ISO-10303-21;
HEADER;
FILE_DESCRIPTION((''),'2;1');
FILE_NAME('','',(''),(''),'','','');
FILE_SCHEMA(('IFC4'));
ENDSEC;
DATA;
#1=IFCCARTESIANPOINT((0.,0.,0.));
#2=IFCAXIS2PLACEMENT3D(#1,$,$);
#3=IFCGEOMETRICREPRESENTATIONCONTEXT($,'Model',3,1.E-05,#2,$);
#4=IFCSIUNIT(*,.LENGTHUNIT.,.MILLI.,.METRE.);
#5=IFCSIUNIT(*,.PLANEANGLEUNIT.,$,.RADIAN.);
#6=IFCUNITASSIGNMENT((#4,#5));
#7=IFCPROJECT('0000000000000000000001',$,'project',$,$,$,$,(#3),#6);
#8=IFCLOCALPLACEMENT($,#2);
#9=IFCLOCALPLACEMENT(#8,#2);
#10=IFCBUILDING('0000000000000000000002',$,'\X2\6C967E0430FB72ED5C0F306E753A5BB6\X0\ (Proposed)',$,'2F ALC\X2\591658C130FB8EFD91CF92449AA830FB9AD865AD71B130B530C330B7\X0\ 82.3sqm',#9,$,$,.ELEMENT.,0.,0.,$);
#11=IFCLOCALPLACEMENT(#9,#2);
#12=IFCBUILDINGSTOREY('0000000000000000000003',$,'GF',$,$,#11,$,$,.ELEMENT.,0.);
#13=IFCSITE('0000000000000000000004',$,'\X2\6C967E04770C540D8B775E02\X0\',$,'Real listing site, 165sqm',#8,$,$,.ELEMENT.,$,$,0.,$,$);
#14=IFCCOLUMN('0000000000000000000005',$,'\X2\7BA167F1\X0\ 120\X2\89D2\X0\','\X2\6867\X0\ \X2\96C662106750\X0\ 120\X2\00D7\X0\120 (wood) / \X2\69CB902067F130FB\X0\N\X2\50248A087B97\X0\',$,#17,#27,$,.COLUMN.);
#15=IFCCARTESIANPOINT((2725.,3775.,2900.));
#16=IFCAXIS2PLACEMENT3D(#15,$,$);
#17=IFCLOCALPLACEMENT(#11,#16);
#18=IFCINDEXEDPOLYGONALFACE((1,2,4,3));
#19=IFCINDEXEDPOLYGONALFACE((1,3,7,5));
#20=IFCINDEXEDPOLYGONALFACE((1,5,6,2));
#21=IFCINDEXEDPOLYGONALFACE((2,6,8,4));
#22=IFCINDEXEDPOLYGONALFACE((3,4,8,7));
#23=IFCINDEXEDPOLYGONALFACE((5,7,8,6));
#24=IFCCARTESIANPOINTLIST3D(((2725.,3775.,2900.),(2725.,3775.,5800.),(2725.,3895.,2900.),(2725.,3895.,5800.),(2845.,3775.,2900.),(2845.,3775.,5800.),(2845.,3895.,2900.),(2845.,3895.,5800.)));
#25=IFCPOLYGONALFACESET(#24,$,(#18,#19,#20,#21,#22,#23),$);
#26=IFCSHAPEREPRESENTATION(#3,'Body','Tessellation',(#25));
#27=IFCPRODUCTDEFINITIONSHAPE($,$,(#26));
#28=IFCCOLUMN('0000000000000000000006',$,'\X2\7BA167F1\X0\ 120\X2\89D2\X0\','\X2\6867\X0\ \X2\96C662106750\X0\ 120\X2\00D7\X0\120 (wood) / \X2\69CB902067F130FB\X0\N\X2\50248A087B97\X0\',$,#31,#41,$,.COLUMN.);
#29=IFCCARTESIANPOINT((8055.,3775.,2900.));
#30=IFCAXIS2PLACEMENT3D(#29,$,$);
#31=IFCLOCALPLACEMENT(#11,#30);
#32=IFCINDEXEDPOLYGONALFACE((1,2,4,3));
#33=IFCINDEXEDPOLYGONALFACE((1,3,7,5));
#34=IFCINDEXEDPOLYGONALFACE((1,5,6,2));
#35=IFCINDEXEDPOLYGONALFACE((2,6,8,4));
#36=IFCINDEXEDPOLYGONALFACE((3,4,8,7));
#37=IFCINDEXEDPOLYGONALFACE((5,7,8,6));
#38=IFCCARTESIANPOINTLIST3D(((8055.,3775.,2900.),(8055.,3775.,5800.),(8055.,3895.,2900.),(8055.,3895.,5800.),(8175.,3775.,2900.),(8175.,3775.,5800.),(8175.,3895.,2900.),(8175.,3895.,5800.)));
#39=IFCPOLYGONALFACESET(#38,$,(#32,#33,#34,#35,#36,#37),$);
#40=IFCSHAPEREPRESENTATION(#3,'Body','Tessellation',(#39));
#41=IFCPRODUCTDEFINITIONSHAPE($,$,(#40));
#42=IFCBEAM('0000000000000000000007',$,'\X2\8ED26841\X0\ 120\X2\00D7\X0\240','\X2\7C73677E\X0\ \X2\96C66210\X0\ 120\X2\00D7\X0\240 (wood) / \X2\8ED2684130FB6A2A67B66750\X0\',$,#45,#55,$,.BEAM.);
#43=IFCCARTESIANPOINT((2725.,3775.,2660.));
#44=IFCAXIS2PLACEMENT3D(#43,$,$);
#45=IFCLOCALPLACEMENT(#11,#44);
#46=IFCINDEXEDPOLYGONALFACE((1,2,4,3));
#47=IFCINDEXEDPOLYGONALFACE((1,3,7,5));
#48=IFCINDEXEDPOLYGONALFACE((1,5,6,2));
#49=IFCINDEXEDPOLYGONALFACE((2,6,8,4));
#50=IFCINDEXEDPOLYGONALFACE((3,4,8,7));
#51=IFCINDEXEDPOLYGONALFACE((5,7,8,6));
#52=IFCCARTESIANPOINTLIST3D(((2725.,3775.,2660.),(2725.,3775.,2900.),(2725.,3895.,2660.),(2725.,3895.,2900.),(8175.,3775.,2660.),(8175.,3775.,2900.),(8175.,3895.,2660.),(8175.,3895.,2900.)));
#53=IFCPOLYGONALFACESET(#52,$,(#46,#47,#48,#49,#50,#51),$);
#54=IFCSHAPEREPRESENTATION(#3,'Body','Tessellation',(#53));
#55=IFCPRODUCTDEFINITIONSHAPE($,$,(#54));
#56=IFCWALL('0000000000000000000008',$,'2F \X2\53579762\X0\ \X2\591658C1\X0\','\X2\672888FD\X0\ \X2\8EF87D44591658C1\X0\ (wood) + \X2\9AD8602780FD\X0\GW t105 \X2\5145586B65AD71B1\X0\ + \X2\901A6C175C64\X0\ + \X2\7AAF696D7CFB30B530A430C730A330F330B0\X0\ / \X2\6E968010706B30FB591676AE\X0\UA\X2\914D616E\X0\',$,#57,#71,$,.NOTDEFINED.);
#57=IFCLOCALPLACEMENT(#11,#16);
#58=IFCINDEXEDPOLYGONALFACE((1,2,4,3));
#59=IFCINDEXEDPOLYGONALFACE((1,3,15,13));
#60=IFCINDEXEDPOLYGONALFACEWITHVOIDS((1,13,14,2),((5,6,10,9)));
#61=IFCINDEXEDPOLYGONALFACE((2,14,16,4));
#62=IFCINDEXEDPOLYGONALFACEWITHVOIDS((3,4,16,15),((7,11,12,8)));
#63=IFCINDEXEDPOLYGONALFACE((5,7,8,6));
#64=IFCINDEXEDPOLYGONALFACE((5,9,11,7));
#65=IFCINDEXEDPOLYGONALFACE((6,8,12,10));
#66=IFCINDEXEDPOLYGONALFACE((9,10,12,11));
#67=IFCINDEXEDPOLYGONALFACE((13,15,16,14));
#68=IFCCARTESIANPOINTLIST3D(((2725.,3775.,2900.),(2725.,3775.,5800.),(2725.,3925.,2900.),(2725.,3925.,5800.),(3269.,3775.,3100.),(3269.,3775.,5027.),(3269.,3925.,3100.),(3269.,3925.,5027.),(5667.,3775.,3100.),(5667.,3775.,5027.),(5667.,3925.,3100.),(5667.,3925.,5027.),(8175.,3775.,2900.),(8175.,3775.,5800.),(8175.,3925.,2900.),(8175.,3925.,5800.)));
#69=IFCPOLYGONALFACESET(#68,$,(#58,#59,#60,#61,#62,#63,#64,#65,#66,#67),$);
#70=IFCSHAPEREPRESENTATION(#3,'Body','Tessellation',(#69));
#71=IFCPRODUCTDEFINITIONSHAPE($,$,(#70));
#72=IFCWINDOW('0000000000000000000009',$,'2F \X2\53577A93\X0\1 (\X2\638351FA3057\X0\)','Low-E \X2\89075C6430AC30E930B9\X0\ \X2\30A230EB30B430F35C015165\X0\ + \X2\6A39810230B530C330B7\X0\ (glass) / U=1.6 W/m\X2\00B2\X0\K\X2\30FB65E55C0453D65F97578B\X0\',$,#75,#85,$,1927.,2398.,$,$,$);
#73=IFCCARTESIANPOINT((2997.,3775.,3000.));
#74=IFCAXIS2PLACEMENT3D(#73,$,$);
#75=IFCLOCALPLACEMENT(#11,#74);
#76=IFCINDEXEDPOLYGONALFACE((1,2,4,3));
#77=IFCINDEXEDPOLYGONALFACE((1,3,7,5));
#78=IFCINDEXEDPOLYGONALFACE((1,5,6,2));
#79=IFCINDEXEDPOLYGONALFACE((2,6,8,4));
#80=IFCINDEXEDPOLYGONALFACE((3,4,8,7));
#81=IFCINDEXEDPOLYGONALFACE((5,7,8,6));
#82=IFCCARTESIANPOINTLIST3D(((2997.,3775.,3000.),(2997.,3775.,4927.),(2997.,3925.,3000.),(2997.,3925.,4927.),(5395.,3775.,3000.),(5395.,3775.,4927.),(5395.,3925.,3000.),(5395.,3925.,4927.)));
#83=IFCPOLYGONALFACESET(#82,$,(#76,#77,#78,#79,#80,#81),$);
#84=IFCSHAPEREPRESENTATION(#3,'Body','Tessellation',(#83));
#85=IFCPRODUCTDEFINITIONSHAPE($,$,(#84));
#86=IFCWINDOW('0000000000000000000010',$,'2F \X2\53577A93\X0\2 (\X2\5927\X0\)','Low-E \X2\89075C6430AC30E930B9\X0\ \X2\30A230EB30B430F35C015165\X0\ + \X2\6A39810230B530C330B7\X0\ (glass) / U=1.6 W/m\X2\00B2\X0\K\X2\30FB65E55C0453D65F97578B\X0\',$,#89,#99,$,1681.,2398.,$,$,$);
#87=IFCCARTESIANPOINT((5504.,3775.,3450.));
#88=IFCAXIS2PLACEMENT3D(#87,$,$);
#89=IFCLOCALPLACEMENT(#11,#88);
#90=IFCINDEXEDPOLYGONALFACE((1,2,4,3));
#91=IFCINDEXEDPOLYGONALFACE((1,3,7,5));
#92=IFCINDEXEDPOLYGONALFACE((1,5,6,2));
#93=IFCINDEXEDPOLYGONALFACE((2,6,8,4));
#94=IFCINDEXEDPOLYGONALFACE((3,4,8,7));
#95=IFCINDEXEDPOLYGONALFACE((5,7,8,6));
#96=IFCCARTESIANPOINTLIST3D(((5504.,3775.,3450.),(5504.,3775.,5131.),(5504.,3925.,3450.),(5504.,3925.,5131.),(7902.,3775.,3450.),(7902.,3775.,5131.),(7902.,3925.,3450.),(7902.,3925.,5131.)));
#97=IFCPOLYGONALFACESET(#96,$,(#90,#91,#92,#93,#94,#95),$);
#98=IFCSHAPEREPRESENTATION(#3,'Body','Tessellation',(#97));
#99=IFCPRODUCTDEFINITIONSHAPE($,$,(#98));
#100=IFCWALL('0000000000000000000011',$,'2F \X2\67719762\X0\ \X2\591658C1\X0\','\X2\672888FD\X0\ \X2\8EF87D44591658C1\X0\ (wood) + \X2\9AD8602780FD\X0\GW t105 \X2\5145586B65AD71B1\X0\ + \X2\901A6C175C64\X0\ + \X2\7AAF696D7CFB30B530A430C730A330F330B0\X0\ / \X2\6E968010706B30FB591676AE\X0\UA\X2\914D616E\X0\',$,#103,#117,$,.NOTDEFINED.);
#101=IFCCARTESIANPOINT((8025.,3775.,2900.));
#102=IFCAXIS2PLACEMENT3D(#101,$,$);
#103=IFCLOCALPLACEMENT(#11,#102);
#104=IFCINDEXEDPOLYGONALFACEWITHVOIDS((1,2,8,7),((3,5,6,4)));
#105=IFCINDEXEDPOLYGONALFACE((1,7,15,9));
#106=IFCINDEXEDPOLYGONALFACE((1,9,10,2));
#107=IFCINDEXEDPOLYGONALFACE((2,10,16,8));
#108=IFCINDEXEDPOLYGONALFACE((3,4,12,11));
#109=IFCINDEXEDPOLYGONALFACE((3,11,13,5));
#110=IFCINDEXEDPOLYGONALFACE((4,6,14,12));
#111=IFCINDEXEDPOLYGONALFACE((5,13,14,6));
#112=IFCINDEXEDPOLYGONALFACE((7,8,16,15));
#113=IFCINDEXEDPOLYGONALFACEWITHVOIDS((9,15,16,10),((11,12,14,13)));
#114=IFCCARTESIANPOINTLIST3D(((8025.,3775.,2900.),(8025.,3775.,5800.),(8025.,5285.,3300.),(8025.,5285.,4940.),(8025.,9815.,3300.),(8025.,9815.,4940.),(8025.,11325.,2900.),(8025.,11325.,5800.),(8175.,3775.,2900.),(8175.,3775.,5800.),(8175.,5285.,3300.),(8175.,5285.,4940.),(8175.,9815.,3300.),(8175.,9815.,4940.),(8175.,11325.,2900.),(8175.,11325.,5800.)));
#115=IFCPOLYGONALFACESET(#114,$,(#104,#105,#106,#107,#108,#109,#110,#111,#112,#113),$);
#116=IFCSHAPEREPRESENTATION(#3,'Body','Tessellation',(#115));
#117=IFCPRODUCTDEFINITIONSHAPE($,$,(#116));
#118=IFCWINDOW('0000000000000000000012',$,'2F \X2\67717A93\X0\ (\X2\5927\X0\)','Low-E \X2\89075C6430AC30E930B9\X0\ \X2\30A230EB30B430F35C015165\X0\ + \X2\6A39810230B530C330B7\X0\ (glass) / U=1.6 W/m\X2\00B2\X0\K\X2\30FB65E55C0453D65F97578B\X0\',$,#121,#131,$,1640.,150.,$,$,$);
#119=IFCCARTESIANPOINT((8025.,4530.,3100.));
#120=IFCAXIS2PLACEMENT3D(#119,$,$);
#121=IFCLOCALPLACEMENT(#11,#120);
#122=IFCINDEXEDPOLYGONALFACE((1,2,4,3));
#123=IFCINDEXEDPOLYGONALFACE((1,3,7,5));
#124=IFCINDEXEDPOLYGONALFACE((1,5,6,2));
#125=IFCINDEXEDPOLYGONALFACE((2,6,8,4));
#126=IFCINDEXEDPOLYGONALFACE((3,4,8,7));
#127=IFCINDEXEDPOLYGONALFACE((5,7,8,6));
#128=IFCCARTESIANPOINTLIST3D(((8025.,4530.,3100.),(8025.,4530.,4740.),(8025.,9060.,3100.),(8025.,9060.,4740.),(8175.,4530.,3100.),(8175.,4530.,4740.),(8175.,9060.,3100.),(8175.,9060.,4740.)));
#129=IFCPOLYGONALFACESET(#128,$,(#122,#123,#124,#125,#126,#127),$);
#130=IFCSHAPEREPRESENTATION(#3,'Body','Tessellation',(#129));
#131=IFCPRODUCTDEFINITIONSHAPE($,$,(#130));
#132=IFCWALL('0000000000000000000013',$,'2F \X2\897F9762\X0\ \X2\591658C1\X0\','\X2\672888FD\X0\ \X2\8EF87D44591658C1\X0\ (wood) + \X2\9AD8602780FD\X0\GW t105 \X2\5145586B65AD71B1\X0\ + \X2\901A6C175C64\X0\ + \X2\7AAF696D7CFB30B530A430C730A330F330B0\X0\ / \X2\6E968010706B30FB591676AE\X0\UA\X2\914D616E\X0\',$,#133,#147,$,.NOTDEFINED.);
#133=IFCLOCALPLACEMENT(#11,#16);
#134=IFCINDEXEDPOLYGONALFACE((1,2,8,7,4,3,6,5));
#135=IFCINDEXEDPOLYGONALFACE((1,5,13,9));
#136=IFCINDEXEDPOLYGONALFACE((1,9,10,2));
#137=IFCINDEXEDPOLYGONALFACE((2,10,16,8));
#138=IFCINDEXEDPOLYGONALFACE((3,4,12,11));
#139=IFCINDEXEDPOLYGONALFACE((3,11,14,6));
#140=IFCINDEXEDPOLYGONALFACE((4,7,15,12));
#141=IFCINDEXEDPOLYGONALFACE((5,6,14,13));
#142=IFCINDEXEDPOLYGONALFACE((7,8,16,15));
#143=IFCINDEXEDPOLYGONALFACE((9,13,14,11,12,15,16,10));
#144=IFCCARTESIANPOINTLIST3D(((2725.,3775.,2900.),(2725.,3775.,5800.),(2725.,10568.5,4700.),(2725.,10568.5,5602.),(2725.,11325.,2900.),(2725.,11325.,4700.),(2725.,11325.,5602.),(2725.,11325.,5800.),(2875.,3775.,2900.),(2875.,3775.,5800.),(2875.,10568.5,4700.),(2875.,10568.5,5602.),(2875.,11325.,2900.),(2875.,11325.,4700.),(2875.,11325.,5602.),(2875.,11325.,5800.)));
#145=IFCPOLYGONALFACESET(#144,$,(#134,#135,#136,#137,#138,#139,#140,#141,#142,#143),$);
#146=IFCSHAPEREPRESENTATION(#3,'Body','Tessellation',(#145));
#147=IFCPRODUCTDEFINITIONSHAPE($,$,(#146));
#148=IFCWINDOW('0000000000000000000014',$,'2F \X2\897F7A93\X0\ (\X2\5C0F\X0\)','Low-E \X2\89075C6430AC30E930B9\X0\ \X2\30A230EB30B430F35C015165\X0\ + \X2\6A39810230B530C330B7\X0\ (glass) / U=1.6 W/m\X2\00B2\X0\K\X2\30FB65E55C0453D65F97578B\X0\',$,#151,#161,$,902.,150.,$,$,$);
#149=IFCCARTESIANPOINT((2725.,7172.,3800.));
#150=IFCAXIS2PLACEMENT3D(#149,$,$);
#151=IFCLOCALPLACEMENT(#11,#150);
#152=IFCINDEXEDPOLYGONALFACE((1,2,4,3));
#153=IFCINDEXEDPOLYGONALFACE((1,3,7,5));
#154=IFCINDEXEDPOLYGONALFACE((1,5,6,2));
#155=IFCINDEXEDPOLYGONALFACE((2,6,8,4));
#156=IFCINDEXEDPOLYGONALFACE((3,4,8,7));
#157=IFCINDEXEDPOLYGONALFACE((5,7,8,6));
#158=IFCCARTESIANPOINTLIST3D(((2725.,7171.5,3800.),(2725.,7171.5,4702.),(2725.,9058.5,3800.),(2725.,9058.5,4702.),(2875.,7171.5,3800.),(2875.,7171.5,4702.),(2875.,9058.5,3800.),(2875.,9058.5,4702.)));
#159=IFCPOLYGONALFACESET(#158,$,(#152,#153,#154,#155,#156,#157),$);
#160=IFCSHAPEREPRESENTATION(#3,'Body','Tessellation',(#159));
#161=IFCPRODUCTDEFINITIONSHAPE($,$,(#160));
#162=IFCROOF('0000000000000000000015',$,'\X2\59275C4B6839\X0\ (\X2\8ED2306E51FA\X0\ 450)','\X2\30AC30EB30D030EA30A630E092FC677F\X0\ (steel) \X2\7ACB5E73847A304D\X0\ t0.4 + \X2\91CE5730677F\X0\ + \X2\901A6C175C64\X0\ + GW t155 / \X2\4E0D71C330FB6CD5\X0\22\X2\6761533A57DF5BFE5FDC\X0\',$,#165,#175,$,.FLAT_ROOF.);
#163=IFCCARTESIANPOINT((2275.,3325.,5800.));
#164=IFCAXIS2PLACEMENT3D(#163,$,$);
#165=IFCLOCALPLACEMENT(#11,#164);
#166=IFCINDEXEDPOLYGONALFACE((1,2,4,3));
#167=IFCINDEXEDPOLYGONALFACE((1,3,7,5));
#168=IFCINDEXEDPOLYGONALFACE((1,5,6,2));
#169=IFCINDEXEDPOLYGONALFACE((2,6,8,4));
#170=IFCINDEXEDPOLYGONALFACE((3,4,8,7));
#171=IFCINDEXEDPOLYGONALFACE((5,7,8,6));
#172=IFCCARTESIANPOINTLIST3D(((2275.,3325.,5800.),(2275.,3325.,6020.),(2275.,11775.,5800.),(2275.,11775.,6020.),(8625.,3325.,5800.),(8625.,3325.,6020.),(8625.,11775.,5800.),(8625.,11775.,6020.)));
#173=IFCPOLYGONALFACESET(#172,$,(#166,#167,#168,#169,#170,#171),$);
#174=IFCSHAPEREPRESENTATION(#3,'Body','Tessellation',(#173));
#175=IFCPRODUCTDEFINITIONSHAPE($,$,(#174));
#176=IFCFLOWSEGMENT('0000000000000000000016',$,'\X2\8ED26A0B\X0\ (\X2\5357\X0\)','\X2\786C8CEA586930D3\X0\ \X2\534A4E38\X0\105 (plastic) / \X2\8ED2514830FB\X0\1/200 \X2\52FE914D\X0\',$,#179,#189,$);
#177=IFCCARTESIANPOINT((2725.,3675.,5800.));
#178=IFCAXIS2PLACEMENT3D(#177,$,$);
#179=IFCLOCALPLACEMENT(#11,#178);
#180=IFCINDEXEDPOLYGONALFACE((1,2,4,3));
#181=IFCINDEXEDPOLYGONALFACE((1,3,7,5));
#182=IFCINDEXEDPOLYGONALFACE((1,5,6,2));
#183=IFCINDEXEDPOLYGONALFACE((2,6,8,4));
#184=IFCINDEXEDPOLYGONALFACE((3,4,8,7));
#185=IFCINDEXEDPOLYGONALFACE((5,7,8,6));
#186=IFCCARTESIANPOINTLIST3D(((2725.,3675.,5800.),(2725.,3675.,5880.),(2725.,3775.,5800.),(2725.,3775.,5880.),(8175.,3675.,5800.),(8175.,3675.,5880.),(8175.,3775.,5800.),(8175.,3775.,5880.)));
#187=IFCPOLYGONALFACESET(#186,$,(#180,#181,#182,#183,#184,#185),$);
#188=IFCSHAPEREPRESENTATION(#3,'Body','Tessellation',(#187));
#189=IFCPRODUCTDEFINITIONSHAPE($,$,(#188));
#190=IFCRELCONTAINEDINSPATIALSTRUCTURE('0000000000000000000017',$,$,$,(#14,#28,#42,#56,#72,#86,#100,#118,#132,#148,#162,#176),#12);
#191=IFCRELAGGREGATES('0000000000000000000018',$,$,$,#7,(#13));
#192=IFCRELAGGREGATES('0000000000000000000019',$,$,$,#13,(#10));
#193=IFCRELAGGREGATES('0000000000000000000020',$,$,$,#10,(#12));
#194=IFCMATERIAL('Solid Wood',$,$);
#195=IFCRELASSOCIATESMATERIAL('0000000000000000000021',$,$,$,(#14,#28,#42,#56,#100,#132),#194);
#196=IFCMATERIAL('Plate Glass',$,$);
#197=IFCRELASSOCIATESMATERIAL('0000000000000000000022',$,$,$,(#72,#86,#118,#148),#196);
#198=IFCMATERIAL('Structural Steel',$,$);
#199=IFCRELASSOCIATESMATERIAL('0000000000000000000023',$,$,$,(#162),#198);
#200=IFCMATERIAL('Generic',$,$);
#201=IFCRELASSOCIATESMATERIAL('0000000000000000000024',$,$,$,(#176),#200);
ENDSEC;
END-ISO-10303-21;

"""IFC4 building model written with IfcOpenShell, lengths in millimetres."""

from ifc_helpers import new_model, si_unit, frame, frame_2d, origin, place, context, project, spatial, rectangle, extrude, material, element, fill, save


model = new_model("IFC4")

# Units and contexts
model_context = context("Model", 3, precision=1e-05, world=origin())
ifc_project = project(units=[si_unit("LENGTHUNIT", "METRE", prefix="MILLI"), si_unit("PLANEANGLEUNIT", "RADIAN")], contexts=[model_context])

# Site, building, storey
site_placement = place(None, origin())
site = spatial("IfcSite", under=ifc_project, at=site_placement, Name="沖縄県名護市", ObjectType="Real listing site, 165sqm", CompositionType="ELEMENT", RefElevation=0.0)
building_placement = place(site_placement, origin())
building = spatial("IfcBuilding", under=site, at=building_placement, Name="沖縄・狭小の町家 (Proposed)", ObjectType="2F ALC外壁・軽量鉄骨・高断熱サッシ 82.3sqm", CompositionType="ELEMENT", ElevationOfRefHeight=0.0, ElevationOfTerrain=0.0)
storey_placement = place(building_placement, origin())
storey = spatial("IfcBuildingStorey", under=building, at=storey_placement, Name="GF", CompositionType="ELEMENT", Elevation=0.0)

# Columns
ifc_material_1 = material(Name="Solid Wood")
column_1_placement = place(storey_placement, frame((2725.0, 3775.0, 2900.0)))
element("IfcColumn", 1, at=column_1_placement, inside=storey, material=ifc_material_1, Name="管柱 120角", Description="桧 集成材 120×120 (wood) / 構造柱・N値計算", PredefinedType="COLUMN", context=model_context, shape_type="SweptSolid", body=[
    extrude(rectangle(XDim=120.0, YDim=120.0, at=frame_2d((60.0, 60.0))), frame((2725.0, 3775.0, 2900.0)), (0.0, 0.0, 1.0), 2900.0),
])
column_2_placement = place(storey_placement, frame((8055.0, 3775.0, 2900.0)))
element("IfcColumn", 2, at=column_2_placement, inside=storey, material=ifc_material_1, Name="管柱 120角", Description="桧 集成材 120×120 (wood) / 構造柱・N値計算", PredefinedType="COLUMN", context=model_context, shape_type="SweptSolid", body=[
    extrude(rectangle(XDim=120.0, YDim=120.0, at=frame_2d((60.0, 60.0))), frame((8055.0, 3775.0, 2900.0)), (0.0, 0.0, 1.0), 2900.0),
])

# Beam
beam_1_placement = place(storey_placement, frame((2725.0, 3775.0, 2660.0)))
element("IfcBeam", 3, at=beam_1_placement, inside=storey, material=ifc_material_1, Name="軒桁 120×240", Description="米松 集成 120×240 (wood) / 軒桁・横架材", PredefinedType="BEAM", context=model_context, shape_type="SweptSolid", body=[
    extrude(rectangle(XDim=5450.0, YDim=120.0, at=frame_2d((2725.0, 60.0))), frame((2725.0, 3775.0, 2660.0)), (0.0, 0.0, 1.0), 240.0),
])

# Wall, openings, windows
wall_1_placement = place(storey_placement, frame((2725.0, 3775.0, 2900.0)))
wall_1 = element("IfcWall", 4, at=wall_1_placement, inside=storey, material=ifc_material_1, Name="2F 南面 外壁", Description="木製 軸組外壁 (wood) + 高性能GW t105 充填断熱 + 通気層 + 窯業系サイディング / 準耐火・外皮UA配慮", PredefinedType="NOTDEFINED", context=model_context, shape_type="SweptSolid", body=[
    extrude(rectangle(XDim=5450.0, YDim=150.0, at=frame_2d((2725.0, 75.0))), frame((2725.0, 3775.0, 2900.0)), (0.0, 0.0, 1.0), 2900.0),
])
opening_1_placement = place(storey_placement, frame((2997.0, 3775.0, 3000.0)))
opening_1 = element("IfcOpeningElement", 5, at=opening_1_placement, cuts=wall_1, PredefinedType="NOTDEFINED", context=model_context, shape_type="SweptSolid", body=[
    extrude(rectangle(XDim=2398.0, YDim=150.0, at=frame_2d((1199.0, 75.0))), frame((2997.0, 3775.0, 3000.0)), (0.0, 0.0, 1.0), 1927.0),
])
opening_2_placement = place(storey_placement, frame((5504.0, 3775.0, 3450.0)))
opening_2 = element("IfcOpeningElement", 6, at=opening_2_placement, cuts=wall_1, PredefinedType="NOTDEFINED", context=model_context, shape_type="SweptSolid", body=[
    extrude(rectangle(XDim=2398.0, YDim=150.0, at=frame_2d((1199.0, 75.0))), frame((5504.0, 3775.0, 3450.0)), (0.0, 0.0, 1.0), 1681.0),
])
ifc_material_2 = material(Name="Plate Glass")
window_1_placement = place(storey_placement, frame((2997.0, 3775.0, 3000.0)))
window_1 = element("IfcWindow", 7, at=window_1_placement, inside=storey, material=ifc_material_2, Name="2F 南窓1 (掃出し)", Description="Low-E 複層ガラス アルゴン封入 + 樹脂サッシ (glass) / U=1.6 W/m²K・日射取得型", OverallHeight=1927.0, OverallWidth=2398.0, context=model_context, shape_type="SweptSolid", body=[
    extrude(rectangle(XDim=2398.0, YDim=150.0, at=frame_2d((1199.0, 75.0))), frame((2997.0, 3775.0, 3000.0)), (0.0, 0.0, 1.0), 1927.0),
])
fill(opening_1, window_1)
window_2_placement = place(storey_placement, frame((5504.0, 3775.0, 3450.0)))
window_2 = element("IfcWindow", 8, at=window_2_placement, inside=storey, material=ifc_material_2, Name="2F 南窓2 (大)", Description="Low-E 複層ガラス アルゴン封入 + 樹脂サッシ (glass) / U=1.6 W/m²K・日射取得型", OverallHeight=1681.0, OverallWidth=2398.0, context=model_context, shape_type="SweptSolid", body=[
    extrude(rectangle(XDim=2398.0, YDim=150.0, at=frame_2d((1199.0, 75.0))), frame((5504.0, 3775.0, 3450.0)), (0.0, 0.0, 1.0), 1681.0),
])
fill(opening_2, window_2)

# Walls, openings, windows
wall_2_placement = place(storey_placement, frame((8025.0, 3775.0, 2900.0)))
wall_2 = element("IfcWall", 9, at=wall_2_placement, inside=storey, material=ifc_material_1, Name="2F 東面 外壁", Description="木製 軸組外壁 (wood) + 高性能GW t105 充填断熱 + 通気層 + 窯業系サイディング / 準耐火・外皮UA配慮", PredefinedType="NOTDEFINED", context=model_context, shape_type="SweptSolid", body=[
    extrude(rectangle(XDim=150.0, YDim=7550.0, at=frame_2d((75.0, 3775.0))), frame((8025.0, 3775.0, 2900.0)), (0.0, 0.0, 1.0), 2900.0),
])
opening_3_placement = place(storey_placement, frame((8025.0, 4530.0, 3100.0)))
opening_3 = element("IfcOpeningElement", 10, at=opening_3_placement, cuts=wall_2, PredefinedType="NOTDEFINED", context=model_context, shape_type="SweptSolid", body=[
    extrude(rectangle(XDim=150.0, YDim=4530.0, at=frame_2d((75.0, 2265.0))), frame((8025.0, 4530.0, 3100.0)), (0.0, 0.0, 1.0), 1640.0),
])
window_3_placement = place(storey_placement, frame((8025.0, 4530.0, 3100.0)))
window_3 = element("IfcWindow", 11, at=window_3_placement, inside=storey, material=ifc_material_2, Name="2F 東窓 (大)", Description="Low-E 複層ガラス アルゴン封入 + 樹脂サッシ (glass) / U=1.6 W/m²K・日射取得型", OverallHeight=1640.0, OverallWidth=150.0, context=model_context, shape_type="SweptSolid", body=[
    extrude(rectangle(XDim=150.0, YDim=4530.0, at=frame_2d((75.0, 2265.0))), frame((8025.0, 4530.0, 3100.0)), (0.0, 0.0, 1.0), 1640.0),
])
fill(opening_3, window_3)
wall_3_placement = place(storey_placement, frame((2725.0, 3775.0, 2900.0)))
wall_3 = element("IfcWall", 12, at=wall_3_placement, inside=storey, material=ifc_material_1, Name="2F 西面 外壁", Description="木製 軸組外壁 (wood) + 高性能GW t105 充填断熱 + 通気層 + 窯業系サイディング / 準耐火・外皮UA配慮", PredefinedType="NOTDEFINED", context=model_context, shape_type="SweptSolid", body=[
    extrude(rectangle(XDim=150.0, YDim=7550.0, at=frame_2d((75.0, 3775.0))), frame((2725.0, 3775.0, 2900.0)), (0.0, 0.0, 1.0), 2900.0),
])
opening_4_placement = place(storey_placement, frame((2725.0, 7172.0, 3800.0)))
opening_4 = element("IfcOpeningElement", 13, at=opening_4_placement, cuts=wall_3, PredefinedType="NOTDEFINED", context=model_context, shape_type="SweptSolid", body=[
    extrude(rectangle(XDim=150.0, YDim=1887.0, at=frame_2d((75.0, 943.0))), frame((2725.0, 7172.0, 3800.0)), (0.0, 0.0, 1.0), 902.0),
])
window_4_placement = place(storey_placement, frame((2725.0, 7172.0, 3800.0)))
window_4 = element("IfcWindow", 14, at=window_4_placement, inside=storey, material=ifc_material_2, Name="2F 西窓 (小)", Description="Low-E 複層ガラス アルゴン封入 + 樹脂サッシ (glass) / U=1.6 W/m²K・日射取得型", OverallHeight=902.0, OverallWidth=150.0, context=model_context, shape_type="SweptSolid", body=[
    extrude(rectangle(XDim=150.0, YDim=1887.0, at=frame_2d((75.0, 943.0))), frame((2725.0, 7172.0, 3800.0)), (0.0, 0.0, 1.0), 902.0),
])
fill(opening_4, window_4)

# Roof
ifc_material_3 = material(Name="Structural Steel")
roof_placement = place(storey_placement, frame((2275.0, 3325.0, 5800.0)))
element("IfcRoof", 15, at=roof_placement, inside=storey, material=ifc_material_3, Name="大屋根 (軒の出 450)", Description="ガルバリウム鋼板 (steel) 立平葺き t0.4 + 野地板 + 通気層 + GW t155 / 不燃・法22条区域対応", PredefinedType="FLAT_ROOF", context=model_context, shape_type="SweptSolid", body=[
    extrude(rectangle(XDim=6350.0, YDim=8450.0, at=frame_2d((3175.0, 4225.0))), frame((2275.0, 3325.0, 5800.0)), (0.0, 0.0, 1.0), 220.0),
])

# Flow segment
ifc_material_4 = material(Name="Generic")
flow_segment_placement = place(storey_placement, frame((2725.0, 3675.0, 5800.0)))
element("IfcFlowSegment", 16, at=flow_segment_placement, inside=storey, material=ifc_material_4, Name="軒樋 (南)", Description="硬質塩ビ 半丸105 (plastic) / 軒先・1/200 勾配", context=model_context, shape_type="SweptSolid", body=[
    extrude(rectangle(XDim=5450.0, YDim=100.0, at=frame_2d((2725.0, 50.0))), frame((2725.0, 3675.0, 5800.0)), (0.0, 0.0, 1.0), 80.0),
])

save(model, "model.ifc")
